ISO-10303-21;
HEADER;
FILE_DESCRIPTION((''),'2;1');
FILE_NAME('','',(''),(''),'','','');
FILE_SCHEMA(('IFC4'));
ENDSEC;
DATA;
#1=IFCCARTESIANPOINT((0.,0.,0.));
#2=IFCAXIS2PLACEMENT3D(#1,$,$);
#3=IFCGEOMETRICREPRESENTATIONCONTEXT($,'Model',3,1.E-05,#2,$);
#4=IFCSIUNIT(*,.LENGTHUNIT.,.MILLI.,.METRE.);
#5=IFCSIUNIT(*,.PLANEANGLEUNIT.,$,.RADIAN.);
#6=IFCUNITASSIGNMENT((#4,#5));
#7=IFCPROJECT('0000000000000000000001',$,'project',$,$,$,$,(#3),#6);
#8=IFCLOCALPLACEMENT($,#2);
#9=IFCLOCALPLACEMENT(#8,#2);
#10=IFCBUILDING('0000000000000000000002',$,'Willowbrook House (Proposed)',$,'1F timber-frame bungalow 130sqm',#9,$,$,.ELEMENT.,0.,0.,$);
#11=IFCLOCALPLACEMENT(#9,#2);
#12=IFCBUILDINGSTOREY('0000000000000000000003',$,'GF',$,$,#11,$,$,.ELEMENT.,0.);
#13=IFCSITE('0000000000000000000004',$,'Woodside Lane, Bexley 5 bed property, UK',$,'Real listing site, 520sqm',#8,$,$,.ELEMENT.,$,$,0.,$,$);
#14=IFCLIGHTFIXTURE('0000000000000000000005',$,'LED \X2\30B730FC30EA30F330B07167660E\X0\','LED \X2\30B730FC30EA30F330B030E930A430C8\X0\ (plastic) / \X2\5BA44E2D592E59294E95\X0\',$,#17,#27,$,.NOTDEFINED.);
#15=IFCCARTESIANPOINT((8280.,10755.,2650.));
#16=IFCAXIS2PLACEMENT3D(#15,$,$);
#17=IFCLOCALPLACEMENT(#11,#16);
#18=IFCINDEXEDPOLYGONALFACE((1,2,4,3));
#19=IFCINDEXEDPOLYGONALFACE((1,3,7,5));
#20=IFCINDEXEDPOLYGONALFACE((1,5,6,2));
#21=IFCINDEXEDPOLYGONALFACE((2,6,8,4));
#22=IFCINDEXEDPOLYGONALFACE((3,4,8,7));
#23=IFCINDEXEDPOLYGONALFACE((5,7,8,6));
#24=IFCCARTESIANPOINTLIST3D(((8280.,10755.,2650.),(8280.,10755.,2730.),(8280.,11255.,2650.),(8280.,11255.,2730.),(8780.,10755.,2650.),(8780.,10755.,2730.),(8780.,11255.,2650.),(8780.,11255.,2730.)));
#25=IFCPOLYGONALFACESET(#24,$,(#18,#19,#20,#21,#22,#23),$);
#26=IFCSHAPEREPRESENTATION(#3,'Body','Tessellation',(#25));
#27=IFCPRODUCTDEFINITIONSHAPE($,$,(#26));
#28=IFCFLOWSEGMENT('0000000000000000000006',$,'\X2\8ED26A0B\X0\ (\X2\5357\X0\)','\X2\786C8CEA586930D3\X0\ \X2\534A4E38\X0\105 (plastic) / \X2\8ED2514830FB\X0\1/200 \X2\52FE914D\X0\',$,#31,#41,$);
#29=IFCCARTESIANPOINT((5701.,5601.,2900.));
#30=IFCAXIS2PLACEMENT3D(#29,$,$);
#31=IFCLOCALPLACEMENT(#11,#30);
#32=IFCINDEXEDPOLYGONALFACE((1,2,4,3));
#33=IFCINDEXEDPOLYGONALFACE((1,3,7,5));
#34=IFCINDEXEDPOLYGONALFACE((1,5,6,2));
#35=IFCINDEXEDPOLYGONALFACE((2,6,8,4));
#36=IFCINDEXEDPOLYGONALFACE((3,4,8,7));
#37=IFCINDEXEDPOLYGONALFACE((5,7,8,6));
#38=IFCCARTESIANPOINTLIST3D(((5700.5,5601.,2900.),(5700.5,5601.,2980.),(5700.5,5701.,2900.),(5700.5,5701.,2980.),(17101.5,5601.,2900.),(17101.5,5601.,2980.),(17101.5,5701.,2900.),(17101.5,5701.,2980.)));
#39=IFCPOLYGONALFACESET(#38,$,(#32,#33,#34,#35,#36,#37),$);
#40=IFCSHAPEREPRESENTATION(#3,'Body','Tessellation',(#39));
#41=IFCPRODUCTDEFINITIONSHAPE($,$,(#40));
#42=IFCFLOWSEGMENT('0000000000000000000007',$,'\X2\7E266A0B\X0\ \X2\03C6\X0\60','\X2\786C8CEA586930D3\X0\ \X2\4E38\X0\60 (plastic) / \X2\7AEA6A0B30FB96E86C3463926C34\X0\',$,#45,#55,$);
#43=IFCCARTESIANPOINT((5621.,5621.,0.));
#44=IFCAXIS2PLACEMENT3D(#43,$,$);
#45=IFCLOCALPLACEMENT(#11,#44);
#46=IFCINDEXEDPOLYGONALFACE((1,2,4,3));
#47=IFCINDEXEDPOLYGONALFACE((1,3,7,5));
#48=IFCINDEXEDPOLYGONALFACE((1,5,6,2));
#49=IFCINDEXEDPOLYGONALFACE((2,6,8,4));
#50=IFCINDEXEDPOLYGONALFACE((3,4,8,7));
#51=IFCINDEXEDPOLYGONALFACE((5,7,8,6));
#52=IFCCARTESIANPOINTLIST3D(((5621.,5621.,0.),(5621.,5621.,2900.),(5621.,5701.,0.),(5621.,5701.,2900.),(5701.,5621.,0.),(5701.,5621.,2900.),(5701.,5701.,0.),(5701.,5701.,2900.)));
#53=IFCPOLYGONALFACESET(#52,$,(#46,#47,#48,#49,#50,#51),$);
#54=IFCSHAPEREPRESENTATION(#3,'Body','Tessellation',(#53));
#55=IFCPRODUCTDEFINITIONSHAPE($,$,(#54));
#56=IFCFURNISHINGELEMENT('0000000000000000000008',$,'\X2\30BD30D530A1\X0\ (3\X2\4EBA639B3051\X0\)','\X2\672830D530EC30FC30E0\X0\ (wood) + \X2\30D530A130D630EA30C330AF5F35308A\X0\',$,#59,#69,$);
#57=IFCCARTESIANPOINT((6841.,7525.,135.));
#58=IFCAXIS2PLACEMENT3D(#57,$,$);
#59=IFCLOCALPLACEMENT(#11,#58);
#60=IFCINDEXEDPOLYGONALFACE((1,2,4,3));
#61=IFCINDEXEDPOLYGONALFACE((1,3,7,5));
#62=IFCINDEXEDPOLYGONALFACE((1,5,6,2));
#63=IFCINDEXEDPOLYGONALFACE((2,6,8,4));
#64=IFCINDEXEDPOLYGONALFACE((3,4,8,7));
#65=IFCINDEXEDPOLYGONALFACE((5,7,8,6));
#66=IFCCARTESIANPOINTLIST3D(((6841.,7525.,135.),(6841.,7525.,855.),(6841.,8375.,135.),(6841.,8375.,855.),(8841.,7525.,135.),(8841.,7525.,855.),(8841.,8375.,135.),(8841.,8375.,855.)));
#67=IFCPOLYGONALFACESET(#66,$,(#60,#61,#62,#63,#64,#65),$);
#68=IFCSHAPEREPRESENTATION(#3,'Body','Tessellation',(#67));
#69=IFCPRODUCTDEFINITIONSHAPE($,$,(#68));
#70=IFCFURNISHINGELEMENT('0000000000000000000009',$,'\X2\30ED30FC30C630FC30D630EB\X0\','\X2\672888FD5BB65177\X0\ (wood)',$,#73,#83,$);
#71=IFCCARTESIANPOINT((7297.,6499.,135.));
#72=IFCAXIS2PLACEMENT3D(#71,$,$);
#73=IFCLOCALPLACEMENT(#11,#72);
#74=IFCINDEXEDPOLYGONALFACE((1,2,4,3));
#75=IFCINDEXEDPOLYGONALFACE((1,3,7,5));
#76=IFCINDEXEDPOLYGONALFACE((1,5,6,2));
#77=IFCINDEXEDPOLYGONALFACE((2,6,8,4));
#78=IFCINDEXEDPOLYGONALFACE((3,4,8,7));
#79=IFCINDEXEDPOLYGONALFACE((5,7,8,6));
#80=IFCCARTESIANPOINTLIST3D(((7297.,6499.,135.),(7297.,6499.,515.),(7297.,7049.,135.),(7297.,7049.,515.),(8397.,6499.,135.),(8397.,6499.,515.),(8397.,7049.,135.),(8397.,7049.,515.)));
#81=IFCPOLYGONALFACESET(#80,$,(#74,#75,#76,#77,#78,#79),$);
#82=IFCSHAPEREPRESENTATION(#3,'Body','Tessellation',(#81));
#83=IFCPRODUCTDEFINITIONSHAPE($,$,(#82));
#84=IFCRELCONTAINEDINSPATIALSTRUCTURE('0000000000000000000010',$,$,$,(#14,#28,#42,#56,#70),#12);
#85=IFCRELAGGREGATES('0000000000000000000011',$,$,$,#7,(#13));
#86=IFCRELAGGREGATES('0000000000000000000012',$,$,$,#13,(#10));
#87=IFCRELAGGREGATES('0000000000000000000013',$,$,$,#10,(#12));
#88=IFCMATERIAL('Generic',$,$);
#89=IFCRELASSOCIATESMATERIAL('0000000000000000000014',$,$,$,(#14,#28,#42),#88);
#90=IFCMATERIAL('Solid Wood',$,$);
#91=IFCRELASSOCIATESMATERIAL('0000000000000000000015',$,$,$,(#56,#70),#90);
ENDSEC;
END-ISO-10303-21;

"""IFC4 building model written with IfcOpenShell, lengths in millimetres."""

from ifc_helpers import new_model, si_unit, frame, frame_2d, origin, place, context, project, spatial, rectangle, extrude, material, element, save


model = new_model("IFC4")

# Units and contexts
model_context = context("Model", 3, precision=1e-05, world=origin())
ifc_project = project(units=[si_unit("LENGTHUNIT", "METRE", prefix="MILLI"), si_unit("PLANEANGLEUNIT", "RADIAN")], contexts=[model_context])

# Site, building, storey
site_placement = place(None, origin())
site = spatial("IfcSite", under=ifc_project, at=site_placement, Name="Woodside Lane, Bexley 5 bed property, UK", ObjectType="Real listing site, 520sqm", CompositionType="ELEMENT", RefElevation=0.0)
building_placement = place(site_placement, origin())
building = spatial("IfcBuilding", under=site, at=building_placement, Name="Willowbrook House (Proposed)", ObjectType="1F timber-frame bungalow 130sqm", CompositionType="ELEMENT", ElevationOfRefHeight=0.0, ElevationOfTerrain=0.0)
storey_placement = place(building_placement, origin())
storey = spatial("IfcBuildingStorey", under=building, at=storey_placement, Name="GF", CompositionType="ELEMENT", Elevation=0.0)

# Shared definitions
ifc_material_1 = material(Name="Solid Wood")

# Shared definitions
ifc_material_2 = material(Name="Generic")

# Light fixture
light_fixture_placement = place(storey_placement, frame((8280.0, 10755.0, 2650.0)))
element("IfcLightFixture", 1, at=light_fixture_placement, inside=storey, material=ifc_material_2, Name="LED シーリング照明", Description="LED シーリングライト (plastic) / 室中央天井", PredefinedType="NOTDEFINED", context=model_context, shape_type="SweptSolid", body=[
    extrude(rectangle(XDim=500.0, YDim=500.0, at=frame_2d((250.0, 250.0))), frame((8280.0, 10755.0, 2650.0)), (0.0, 0.0, 1.0), 80.0),
])

# Flow segments
flow_segment_1_placement = place(storey_placement, frame((5701.0, 5601.0, 2900.0)))
element("IfcFlowSegment", 2, at=flow_segment_1_placement, inside=storey, material=ifc_material_2, Name="軒樋 (南)", Description="硬質塩ビ 半丸105 (plastic) / 軒先・1/200 勾配", context=model_context, shape_type="SweptSolid", body=[
    extrude(rectangle(XDim=11401.0, YDim=100.0, at=frame_2d((5700.0, 50.0))), frame((5701.0, 5601.0, 2900.0)), (0.0, 0.0, 1.0), 80.0),
])
flow_segment_2_placement = place(storey_placement, frame((5621.0, 5621.0, 0.0)))
element("IfcFlowSegment", 3, at=flow_segment_2_placement, inside=storey, material=ifc_material_2, Name="縦樋 φ60", Description="硬質塩ビ 丸60 (plastic) / 竪樋・雨水排水", context=model_context, shape_type="SweptSolid", body=[
    extrude(rectangle(XDim=80.0, YDim=80.0, at=frame_2d((40.0, 40.0))), frame((5621.0, 5621.0, 0.0)), (0.0, 0.0, 1.0), 2900.0),
])

# Furnishing elements
furnishing_1_placement = place(storey_placement, frame((6841.0, 7525.0, 135.0)))
element("IfcFurnishingElement", 4, at=furnishing_1_placement, inside=storey, material=ifc_material_1, Name="ソファ (3人掛け)", Description="木フレーム (wood) + ファブリック張り", context=model_context, shape_type="SweptSolid", body=[
    extrude(rectangle(XDim=2000.0, YDim=850.0, at=frame_2d((1000.0, 425.0))), frame((6841.0, 7525.0, 135.0)), (0.0, 0.0, 1.0), 720.0),
])
furnishing_2_placement = place(storey_placement, frame((7297.0, 6499.0, 135.0)))
element("IfcFurnishingElement", 5, at=furnishing_2_placement, inside=storey, material=ifc_material_1, Name="ローテーブル", Description="木製家具 (wood)", context=model_context, shape_type="SweptSolid", body=[
    extrude(rectangle(XDim=1100.0, YDim=550.0, at=frame_2d((550.0, 275.0))), frame((7297.0, 6499.0, 135.0)), (0.0, 0.0, 1.0), 380.0),
])

save(model, "model.ifc")
